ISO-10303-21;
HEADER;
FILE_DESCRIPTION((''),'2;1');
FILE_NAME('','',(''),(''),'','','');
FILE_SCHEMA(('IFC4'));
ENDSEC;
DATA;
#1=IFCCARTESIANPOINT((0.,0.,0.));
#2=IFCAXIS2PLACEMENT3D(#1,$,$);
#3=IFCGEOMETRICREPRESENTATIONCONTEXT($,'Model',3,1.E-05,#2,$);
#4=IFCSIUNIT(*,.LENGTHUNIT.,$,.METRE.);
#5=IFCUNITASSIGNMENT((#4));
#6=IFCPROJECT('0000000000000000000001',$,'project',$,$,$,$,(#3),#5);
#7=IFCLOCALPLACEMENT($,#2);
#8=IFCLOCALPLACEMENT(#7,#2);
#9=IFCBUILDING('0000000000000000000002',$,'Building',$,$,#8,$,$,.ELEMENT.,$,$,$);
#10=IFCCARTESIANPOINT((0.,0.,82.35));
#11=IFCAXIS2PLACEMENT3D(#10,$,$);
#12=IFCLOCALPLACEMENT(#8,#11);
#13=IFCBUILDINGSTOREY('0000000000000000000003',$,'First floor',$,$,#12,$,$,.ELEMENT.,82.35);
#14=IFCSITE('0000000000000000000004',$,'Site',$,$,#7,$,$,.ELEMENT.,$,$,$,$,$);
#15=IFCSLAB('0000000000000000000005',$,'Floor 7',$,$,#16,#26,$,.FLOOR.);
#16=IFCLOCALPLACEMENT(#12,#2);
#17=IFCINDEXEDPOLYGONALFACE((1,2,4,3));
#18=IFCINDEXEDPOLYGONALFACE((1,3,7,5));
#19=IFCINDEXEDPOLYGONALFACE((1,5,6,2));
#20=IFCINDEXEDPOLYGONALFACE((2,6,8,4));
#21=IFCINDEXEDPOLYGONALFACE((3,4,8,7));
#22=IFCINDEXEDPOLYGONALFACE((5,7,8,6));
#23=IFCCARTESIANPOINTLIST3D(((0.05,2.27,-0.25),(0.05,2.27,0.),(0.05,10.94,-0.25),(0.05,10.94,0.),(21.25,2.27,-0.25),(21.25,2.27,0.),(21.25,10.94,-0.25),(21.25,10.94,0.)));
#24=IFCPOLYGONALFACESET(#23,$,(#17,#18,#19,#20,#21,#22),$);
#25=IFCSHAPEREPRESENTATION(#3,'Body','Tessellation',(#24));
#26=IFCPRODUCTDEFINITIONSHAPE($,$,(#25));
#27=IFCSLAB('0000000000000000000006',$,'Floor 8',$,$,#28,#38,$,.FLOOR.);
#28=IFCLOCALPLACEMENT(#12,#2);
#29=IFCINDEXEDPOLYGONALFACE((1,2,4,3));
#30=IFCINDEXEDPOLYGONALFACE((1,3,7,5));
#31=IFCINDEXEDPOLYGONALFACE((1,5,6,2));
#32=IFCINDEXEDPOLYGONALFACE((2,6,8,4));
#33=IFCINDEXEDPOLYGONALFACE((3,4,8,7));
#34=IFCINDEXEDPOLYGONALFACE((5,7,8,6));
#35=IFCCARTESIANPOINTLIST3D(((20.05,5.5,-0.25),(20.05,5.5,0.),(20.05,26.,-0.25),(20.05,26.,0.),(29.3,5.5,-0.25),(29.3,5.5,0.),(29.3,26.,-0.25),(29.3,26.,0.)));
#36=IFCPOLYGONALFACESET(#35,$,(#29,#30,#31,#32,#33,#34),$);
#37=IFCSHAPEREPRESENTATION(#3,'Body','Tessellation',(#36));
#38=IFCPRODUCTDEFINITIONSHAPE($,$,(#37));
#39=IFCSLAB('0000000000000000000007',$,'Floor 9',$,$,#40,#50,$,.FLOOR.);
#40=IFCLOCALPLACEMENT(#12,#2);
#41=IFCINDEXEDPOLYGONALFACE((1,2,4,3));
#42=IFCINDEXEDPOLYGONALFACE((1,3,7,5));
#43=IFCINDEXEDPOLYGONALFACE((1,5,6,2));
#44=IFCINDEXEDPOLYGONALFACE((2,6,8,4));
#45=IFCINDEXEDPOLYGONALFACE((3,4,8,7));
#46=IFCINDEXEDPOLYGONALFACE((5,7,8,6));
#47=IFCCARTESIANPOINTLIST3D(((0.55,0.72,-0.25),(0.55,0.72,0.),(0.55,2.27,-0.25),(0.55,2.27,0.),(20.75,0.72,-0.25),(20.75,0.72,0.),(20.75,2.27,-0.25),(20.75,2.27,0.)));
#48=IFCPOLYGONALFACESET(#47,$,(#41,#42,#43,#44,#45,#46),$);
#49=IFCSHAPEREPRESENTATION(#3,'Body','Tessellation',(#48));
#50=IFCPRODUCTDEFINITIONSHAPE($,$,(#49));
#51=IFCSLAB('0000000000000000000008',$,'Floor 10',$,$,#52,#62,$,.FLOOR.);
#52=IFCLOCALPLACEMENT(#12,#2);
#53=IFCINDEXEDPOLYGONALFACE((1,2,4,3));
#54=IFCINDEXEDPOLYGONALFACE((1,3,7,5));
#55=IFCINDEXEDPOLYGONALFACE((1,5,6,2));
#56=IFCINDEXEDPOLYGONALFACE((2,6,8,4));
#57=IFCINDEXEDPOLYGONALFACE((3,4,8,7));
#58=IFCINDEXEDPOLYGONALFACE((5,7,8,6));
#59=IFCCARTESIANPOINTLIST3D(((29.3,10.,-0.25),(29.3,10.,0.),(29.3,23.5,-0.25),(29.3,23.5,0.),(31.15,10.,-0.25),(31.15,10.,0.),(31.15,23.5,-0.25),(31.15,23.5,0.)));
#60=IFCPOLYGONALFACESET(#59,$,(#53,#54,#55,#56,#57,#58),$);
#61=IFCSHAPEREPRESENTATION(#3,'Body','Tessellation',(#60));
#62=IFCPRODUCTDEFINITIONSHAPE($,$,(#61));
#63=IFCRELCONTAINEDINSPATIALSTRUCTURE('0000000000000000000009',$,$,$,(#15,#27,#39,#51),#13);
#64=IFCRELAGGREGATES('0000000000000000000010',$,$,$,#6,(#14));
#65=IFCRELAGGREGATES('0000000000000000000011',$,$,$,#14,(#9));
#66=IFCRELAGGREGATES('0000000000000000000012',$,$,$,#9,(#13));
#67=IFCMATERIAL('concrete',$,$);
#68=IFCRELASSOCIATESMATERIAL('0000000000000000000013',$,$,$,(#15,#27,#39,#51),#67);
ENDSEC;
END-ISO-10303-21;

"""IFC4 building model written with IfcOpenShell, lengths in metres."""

from ifc_helpers import new_model, si_unit, frame, origin, place, context, project, spatial, polyline, outline, extrude, material, element, save


model = new_model("IFC4")

# Units and contexts
model_context = context("Model", 3, precision=1e-05, world=origin())
ifc_project = project(units=[si_unit("LENGTHUNIT", "METRE")], contexts=[model_context])

# Site, building, storey
site_placement = place(None, origin())
site = spatial("IfcSite", under=ifc_project, at=site_placement, Name="Site", CompositionType="ELEMENT")
building_placement = place(site_placement, origin())
building = spatial("IfcBuilding", under=site, at=building_placement, Name="Building", CompositionType="ELEMENT")
storey_placement = place(building_placement, frame((0.0, 0.0, 82.35)))
storey = spatial("IfcBuildingStorey", under=building, at=storey_placement, Name="First floor", CompositionType="ELEMENT", Elevation=82.35)

# Slabs
ifc_material = material(Name="concrete")
slab_1_placement = place(storey_placement, frame((0.0, 0.0, -0.25), z_axis=(0.0, 0.0, 1.0), x_axis=(1.0, 0.0, 0.0)))
element("IfcSlab", 1, at=slab_1_placement, inside=storey, material=ifc_material, Name="Floor 7", PredefinedType="FLOOR", context=model_context, shape_type="SweptSolid", body=[
    extrude(outline(polyline([(0.05, 2.27), (21.25, 2.27), (21.25, 10.94), (0.05, 10.94), (0.05, 2.27)])), origin(), (0.0, 0.0, 1.0), 0.25),
])
slab_2_placement = place(storey_placement, frame((0.0, 0.0, -0.25), z_axis=(0.0, 0.0, 1.0), x_axis=(1.0, 0.0, 0.0)))
element("IfcSlab", 2, at=slab_2_placement, inside=storey, material=ifc_material, Name="Floor 8", PredefinedType="FLOOR", context=model_context, shape_type="SweptSolid", body=[
    extrude(outline(polyline([(20.05, 5.5), (29.3, 5.5), (29.3, 26.0), (20.05, 26.0), (20.05, 5.5)])), origin(), (0.0, 0.0, 1.0), 0.25),
])
slab_3_placement = place(storey_placement, frame((0.0, 0.0, -0.25), z_axis=(0.0, 0.0, 1.0), x_axis=(1.0, 0.0, 0.0)))
element("IfcSlab", 3, at=slab_3_placement, inside=storey, material=ifc_material, Name="Floor 9", PredefinedType="FLOOR", context=model_context, shape_type="SweptSolid", body=[
    extrude(outline(polyline([(0.55, 0.72), (20.75, 0.72), (20.75, 2.27), (0.55, 2.27), (0.55, 0.72)])), origin(), (0.0, 0.0, 1.0), 0.25),
])
slab_4_placement = place(storey_placement, frame((0.0, 0.0, -0.25), z_axis=(0.0, 0.0, 1.0), x_axis=(1.0, 0.0, 0.0)))
element("IfcSlab", 4, at=slab_4_placement, inside=storey, material=ifc_material, Name="Floor 10", PredefinedType="FLOOR", context=model_context, shape_type="SweptSolid", body=[
    extrude(outline(polyline([(29.3, 10.0), (31.15, 10.0), (31.15, 23.5), (29.3, 23.5), (29.3, 10.0)])), origin(), (0.0, 0.0, 1.0), 0.25),
])

save(model, "model.ifc")
